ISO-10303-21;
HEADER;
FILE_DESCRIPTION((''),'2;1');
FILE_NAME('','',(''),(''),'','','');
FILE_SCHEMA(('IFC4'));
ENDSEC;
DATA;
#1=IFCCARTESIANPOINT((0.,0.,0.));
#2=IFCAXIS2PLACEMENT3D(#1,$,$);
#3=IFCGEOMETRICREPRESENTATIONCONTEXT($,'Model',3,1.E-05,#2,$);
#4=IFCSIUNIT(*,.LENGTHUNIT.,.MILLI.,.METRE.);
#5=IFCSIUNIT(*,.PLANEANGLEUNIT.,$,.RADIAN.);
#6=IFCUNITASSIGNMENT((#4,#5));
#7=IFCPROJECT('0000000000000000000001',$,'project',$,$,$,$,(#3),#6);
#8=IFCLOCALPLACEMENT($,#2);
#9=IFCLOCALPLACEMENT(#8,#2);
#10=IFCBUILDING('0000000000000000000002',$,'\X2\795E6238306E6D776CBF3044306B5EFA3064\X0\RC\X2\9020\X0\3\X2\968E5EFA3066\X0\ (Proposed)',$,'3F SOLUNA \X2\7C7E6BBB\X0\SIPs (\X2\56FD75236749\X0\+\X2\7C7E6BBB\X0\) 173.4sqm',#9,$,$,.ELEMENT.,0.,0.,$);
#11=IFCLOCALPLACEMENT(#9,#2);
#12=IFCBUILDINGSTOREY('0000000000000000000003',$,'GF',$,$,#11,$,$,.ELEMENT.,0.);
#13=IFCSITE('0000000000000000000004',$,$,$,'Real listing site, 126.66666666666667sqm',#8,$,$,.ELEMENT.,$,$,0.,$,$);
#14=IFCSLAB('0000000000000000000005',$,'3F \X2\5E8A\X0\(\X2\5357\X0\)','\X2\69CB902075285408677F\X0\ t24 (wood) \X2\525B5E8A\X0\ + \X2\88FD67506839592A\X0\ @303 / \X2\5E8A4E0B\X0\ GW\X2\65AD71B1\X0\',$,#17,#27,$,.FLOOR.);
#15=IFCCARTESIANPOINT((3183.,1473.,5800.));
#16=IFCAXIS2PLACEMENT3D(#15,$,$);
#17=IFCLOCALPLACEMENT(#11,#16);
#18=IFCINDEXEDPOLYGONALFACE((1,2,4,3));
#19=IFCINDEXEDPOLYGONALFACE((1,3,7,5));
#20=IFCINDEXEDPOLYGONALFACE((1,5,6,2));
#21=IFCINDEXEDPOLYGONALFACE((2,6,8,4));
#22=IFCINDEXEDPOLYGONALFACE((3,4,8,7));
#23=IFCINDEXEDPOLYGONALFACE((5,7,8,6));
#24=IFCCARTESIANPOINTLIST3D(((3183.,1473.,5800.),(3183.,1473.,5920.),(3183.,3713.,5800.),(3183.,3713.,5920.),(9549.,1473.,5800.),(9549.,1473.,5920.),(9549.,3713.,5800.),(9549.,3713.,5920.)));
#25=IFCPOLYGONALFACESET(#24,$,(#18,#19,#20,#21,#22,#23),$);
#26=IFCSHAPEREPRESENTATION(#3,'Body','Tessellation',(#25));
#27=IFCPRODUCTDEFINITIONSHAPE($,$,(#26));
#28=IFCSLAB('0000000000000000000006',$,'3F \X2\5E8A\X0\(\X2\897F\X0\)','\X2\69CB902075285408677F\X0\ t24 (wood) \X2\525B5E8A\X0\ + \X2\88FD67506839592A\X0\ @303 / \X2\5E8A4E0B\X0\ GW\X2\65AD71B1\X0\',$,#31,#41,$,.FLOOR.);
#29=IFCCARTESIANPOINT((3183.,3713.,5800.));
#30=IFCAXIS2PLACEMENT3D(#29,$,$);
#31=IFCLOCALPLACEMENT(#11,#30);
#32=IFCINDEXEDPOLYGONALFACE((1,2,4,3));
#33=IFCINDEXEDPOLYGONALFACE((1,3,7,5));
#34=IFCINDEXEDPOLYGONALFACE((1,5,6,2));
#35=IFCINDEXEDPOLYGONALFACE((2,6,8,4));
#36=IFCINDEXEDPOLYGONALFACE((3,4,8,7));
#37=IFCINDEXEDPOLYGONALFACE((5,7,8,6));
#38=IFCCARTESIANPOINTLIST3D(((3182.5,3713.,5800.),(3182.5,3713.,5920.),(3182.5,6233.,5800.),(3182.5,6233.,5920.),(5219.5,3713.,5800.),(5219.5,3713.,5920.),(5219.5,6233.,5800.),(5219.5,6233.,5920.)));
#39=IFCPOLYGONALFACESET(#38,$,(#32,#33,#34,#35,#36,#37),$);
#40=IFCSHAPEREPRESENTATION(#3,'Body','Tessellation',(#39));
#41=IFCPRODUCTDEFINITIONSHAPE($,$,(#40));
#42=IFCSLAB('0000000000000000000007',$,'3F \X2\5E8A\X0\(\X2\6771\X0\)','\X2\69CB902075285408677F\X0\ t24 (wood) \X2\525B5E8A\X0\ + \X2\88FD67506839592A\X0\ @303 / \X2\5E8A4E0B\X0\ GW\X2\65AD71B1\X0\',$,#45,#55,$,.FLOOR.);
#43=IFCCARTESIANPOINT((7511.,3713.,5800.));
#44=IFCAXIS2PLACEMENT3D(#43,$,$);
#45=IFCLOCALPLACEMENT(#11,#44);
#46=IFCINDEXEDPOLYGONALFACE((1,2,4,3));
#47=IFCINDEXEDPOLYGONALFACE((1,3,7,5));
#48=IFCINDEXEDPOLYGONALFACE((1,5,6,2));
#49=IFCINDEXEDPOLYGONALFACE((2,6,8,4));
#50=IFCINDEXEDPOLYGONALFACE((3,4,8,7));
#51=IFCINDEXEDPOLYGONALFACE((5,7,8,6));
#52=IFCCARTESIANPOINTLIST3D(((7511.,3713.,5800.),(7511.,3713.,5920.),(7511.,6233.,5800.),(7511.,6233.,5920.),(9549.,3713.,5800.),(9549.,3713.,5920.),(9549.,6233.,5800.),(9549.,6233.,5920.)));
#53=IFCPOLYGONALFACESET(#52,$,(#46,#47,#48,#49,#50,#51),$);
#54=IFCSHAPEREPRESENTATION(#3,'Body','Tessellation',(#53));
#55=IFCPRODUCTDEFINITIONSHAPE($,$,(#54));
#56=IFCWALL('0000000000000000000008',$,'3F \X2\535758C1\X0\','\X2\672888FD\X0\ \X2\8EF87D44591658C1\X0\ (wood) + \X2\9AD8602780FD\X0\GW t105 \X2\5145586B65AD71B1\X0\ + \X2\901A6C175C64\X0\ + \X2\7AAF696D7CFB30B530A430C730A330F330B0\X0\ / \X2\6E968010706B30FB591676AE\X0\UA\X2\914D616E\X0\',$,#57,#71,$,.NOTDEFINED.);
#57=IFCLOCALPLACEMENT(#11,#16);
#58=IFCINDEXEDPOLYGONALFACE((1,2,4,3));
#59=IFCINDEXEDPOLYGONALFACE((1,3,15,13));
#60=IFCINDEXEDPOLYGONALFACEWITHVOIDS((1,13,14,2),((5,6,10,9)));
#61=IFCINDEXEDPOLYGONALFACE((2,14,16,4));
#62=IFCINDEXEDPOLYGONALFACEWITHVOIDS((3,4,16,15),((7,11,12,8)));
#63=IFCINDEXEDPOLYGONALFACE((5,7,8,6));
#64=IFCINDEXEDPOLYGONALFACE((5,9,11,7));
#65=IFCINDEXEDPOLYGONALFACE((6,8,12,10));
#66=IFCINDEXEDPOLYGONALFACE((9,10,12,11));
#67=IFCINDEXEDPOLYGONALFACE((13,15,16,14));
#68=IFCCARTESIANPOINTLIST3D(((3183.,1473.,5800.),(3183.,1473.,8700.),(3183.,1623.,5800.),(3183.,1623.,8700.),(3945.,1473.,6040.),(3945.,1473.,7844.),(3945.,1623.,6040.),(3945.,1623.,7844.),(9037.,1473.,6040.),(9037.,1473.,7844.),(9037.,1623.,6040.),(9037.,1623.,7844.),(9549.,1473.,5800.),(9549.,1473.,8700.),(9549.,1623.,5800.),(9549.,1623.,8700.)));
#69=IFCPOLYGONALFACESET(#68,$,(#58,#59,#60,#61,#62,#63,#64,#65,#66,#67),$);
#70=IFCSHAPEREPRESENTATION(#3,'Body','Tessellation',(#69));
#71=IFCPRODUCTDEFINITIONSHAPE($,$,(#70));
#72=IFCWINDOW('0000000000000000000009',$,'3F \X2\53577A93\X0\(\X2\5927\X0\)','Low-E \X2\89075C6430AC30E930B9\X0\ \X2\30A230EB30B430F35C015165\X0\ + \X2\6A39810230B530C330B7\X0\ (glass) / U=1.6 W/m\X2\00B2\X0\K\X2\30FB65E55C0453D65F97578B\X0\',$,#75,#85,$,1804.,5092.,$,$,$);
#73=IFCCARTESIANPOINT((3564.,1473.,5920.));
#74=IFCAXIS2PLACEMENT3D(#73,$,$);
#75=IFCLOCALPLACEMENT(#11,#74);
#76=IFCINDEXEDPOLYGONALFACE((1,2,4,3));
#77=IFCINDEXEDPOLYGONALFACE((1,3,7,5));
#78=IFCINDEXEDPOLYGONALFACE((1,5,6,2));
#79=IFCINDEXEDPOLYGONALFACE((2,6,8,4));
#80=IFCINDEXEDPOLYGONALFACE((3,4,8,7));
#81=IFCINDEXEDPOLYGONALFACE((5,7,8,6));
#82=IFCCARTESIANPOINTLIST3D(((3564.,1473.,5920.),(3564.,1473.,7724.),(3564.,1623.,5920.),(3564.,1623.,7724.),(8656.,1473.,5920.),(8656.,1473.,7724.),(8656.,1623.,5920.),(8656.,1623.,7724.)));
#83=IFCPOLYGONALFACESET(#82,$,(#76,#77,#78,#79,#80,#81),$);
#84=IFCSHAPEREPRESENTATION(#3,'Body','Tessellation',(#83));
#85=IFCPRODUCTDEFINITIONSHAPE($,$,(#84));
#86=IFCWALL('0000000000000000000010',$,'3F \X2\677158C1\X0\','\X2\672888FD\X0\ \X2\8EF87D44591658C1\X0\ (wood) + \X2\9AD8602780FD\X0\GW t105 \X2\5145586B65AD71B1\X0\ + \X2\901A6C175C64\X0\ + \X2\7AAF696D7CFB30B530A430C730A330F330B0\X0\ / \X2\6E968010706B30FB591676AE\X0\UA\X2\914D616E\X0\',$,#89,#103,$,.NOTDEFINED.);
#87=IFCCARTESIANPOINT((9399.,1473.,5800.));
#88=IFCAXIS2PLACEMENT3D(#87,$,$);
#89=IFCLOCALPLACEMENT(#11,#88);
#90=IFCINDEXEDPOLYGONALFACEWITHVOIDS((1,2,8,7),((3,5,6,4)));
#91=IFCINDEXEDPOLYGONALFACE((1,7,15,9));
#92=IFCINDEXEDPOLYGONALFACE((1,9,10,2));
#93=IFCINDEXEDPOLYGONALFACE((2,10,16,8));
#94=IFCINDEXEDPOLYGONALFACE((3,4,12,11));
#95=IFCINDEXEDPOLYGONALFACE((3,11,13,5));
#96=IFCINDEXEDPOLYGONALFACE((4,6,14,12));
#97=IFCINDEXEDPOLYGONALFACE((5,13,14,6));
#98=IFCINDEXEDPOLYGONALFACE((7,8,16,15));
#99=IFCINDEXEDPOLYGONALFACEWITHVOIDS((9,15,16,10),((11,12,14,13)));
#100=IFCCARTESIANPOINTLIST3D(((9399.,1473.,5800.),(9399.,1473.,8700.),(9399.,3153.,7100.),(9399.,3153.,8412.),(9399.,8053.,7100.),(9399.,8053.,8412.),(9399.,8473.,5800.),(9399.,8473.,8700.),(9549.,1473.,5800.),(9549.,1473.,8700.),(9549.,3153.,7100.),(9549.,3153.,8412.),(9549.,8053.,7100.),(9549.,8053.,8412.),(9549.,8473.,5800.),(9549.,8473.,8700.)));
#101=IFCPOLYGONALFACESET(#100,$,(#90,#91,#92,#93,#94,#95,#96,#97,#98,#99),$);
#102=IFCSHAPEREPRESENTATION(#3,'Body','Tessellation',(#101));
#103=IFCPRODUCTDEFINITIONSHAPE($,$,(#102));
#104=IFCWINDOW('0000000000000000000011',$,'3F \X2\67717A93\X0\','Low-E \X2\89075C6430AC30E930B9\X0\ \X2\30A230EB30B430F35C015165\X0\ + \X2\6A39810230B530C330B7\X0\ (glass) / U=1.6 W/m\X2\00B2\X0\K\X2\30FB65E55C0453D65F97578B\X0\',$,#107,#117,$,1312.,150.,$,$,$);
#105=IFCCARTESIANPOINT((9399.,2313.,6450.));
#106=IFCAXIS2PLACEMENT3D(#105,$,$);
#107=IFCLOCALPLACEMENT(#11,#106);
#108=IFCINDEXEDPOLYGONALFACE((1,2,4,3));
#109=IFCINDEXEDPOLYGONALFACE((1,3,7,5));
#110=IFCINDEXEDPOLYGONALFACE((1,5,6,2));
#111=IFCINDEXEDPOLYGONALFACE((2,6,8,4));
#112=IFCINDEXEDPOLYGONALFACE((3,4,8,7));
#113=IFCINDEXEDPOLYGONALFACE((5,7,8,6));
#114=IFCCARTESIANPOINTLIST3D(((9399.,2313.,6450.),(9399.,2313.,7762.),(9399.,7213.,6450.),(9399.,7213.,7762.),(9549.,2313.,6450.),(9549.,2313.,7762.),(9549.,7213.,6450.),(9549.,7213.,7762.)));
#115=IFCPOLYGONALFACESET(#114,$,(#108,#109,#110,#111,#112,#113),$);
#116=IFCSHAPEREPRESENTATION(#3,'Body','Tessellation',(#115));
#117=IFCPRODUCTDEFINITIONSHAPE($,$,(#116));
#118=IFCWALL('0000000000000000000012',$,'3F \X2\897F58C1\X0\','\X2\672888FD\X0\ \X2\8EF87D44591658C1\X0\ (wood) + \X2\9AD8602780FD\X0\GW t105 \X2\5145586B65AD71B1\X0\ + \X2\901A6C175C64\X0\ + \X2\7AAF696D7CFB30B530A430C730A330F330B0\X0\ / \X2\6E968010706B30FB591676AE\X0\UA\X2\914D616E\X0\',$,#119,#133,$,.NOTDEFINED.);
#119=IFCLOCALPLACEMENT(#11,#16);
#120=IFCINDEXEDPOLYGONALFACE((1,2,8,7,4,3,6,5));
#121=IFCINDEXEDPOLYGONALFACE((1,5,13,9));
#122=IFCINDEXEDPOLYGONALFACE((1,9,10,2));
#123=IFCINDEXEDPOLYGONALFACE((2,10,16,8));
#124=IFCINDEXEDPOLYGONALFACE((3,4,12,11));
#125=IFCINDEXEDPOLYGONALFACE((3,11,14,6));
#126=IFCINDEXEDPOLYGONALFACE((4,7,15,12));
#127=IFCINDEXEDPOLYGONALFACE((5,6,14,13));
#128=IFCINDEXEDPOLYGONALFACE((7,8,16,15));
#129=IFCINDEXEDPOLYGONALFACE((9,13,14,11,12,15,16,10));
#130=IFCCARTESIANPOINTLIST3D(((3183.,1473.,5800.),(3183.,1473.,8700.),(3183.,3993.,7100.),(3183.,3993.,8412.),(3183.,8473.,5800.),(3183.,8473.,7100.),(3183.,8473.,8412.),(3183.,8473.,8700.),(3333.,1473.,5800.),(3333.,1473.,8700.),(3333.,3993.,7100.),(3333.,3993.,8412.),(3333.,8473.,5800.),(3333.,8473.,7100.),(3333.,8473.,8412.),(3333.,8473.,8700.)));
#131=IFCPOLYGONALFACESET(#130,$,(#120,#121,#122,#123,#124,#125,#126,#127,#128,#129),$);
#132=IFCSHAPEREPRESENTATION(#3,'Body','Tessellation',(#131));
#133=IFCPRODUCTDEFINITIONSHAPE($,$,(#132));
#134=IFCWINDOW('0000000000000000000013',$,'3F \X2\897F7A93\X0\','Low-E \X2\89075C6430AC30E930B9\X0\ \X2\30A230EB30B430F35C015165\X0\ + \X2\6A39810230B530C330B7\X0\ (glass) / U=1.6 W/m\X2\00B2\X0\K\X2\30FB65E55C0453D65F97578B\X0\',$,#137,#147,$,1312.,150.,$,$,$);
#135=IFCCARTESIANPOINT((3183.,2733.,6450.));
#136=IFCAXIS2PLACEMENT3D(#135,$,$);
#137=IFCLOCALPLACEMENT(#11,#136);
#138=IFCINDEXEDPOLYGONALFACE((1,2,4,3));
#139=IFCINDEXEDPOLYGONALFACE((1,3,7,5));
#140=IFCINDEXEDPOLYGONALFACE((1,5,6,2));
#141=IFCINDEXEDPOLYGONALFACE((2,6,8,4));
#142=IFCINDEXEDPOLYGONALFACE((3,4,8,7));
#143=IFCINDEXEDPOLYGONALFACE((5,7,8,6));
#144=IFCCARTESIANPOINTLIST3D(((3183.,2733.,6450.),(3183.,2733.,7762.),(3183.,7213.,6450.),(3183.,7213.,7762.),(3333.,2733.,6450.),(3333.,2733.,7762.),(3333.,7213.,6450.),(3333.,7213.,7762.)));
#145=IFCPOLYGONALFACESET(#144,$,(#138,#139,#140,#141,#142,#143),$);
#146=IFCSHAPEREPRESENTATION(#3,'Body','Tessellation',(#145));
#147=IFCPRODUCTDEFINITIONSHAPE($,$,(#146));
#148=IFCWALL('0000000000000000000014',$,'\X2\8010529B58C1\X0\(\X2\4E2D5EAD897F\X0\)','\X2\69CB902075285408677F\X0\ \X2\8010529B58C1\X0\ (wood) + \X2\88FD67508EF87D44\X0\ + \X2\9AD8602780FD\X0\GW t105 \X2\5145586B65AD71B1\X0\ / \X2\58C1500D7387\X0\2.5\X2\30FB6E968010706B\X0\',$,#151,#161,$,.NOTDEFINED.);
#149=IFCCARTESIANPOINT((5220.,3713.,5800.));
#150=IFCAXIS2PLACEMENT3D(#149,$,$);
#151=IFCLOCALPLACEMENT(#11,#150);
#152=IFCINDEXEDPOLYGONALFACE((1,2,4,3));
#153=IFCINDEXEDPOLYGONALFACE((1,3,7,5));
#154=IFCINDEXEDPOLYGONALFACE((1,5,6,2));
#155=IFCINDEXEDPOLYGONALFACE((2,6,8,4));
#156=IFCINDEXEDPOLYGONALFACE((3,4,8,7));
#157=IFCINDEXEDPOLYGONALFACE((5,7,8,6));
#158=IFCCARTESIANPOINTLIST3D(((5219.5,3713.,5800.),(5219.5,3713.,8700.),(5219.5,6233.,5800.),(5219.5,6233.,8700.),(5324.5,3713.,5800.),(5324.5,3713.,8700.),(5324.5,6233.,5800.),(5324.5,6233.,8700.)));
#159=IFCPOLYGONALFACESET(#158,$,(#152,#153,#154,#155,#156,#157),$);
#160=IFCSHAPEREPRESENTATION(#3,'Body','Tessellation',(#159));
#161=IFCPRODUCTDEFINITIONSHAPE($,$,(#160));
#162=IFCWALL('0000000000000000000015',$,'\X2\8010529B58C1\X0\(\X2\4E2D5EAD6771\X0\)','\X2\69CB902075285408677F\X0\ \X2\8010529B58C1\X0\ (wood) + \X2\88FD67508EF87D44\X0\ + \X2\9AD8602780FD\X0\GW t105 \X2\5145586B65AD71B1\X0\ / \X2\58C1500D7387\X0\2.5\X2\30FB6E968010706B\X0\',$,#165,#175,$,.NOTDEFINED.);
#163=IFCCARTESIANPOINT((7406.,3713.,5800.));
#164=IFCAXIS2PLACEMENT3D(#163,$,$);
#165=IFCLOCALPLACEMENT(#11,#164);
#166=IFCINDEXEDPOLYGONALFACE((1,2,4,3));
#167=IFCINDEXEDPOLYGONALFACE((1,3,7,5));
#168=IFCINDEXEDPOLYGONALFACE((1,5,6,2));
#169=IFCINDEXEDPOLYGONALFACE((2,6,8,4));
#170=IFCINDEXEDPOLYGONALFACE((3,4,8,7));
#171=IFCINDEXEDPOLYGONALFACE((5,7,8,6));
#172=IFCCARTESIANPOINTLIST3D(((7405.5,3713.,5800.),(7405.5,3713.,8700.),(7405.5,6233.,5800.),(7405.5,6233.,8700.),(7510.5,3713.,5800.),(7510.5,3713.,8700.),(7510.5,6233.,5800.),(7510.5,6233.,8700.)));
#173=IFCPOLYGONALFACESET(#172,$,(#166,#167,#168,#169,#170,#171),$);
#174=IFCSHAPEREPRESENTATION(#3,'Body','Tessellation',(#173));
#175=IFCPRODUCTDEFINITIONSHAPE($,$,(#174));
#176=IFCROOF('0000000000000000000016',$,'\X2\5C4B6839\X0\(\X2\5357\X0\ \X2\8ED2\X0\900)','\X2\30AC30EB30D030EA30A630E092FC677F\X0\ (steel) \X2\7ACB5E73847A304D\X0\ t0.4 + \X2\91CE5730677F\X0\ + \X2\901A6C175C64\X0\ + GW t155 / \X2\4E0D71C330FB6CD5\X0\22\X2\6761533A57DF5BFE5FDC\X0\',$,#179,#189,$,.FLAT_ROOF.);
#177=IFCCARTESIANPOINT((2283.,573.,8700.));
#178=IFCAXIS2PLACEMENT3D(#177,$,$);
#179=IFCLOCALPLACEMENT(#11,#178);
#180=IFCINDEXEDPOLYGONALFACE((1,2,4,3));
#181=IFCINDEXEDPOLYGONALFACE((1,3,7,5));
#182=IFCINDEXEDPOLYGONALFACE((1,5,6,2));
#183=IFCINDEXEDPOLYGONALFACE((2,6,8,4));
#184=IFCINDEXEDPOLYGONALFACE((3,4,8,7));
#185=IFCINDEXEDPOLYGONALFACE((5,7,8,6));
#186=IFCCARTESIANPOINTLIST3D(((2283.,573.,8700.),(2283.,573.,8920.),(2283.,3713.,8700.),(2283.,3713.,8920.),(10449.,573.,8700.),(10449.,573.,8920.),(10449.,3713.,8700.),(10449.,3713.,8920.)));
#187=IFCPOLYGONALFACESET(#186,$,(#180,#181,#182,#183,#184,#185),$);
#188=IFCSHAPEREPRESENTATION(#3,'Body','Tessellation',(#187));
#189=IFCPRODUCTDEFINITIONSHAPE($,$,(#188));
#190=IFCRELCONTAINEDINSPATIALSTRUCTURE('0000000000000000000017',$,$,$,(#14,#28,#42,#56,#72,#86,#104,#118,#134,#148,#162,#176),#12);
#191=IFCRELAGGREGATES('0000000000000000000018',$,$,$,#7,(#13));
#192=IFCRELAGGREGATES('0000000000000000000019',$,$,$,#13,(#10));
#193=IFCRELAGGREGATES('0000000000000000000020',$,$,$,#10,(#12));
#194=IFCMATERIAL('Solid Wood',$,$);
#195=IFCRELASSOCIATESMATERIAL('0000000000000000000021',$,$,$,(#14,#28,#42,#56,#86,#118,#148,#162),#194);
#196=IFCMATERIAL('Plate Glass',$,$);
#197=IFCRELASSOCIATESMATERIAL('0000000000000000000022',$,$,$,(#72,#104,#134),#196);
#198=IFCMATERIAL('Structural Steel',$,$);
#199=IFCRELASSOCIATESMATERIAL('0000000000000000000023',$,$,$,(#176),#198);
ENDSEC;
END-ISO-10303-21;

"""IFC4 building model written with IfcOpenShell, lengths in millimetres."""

from ifc_helpers import new_model, si_unit, frame, frame_2d, origin, place, context, project, spatial, rectangle, extrude, material, element, fill, save


model = new_model("IFC4")

# Units and contexts
model_context = context("Model", 3, precision=1e-05, world=origin())
ifc_project = project(units=[si_unit("LENGTHUNIT", "METRE", prefix="MILLI"), si_unit("PLANEANGLEUNIT", "RADIAN")], contexts=[model_context])

# Site, building, storey
site_placement = place(None, origin())
site = spatial("IfcSite", under=ifc_project, at=site_placement, ObjectType="Real listing site, 126.66666666666667sqm", CompositionType="ELEMENT", RefElevation=0.0)
building_placement = place(site_placement, origin())
building = spatial("IfcBuilding", under=site, at=building_placement, Name="神戸の海沿いに建つRC造3階建て (Proposed)", ObjectType="3F SOLUNA 籾殻SIPs (国産杉+籾殻) 173.4sqm", CompositionType="ELEMENT", ElevationOfRefHeight=0.0, ElevationOfTerrain=0.0)
storey_placement = place(building_placement, origin())
storey = spatial("IfcBuildingStorey", under=building, at=storey_placement, Name="GF", CompositionType="ELEMENT", Elevation=0.0)

# Slabs
ifc_material_1 = material(Name="Solid Wood")
slab_1_placement = place(storey_placement, frame((3183.0, 1473.0, 5800.0)))
element("IfcSlab", 1, at=slab_1_placement, inside=storey, material=ifc_material_1, Name="3F 床(南)", Description="構造用合板 t24 (wood) 剛床 + 製材根太 @303 / 床下 GW断熱", PredefinedType="FLOOR", context=model_context, shape_type="SweptSolid", body=[
    extrude(rectangle(XDim=6366.0, YDim=2240.0, at=frame_2d((3183.0, 1120.0))), frame((3183.0, 1473.0, 5800.0)), (0.0, 0.0, 1.0), 120.0),
])
slab_2_placement = place(storey_placement, frame((3183.0, 3713.0, 5800.0)))
element("IfcSlab", 2, at=slab_2_placement, inside=storey, material=ifc_material_1, Name="3F 床(西)", Description="構造用合板 t24 (wood) 剛床 + 製材根太 @303 / 床下 GW断熱", PredefinedType="FLOOR", context=model_context, shape_type="SweptSolid", body=[
    extrude(rectangle(XDim=2037.0, YDim=2520.0, at=frame_2d((1018.0, 1260.0))), frame((3183.0, 3713.0, 5800.0)), (0.0, 0.0, 1.0), 120.0),
])
slab_3_placement = place(storey_placement, frame((7511.0, 3713.0, 5800.0)))
element("IfcSlab", 3, at=slab_3_placement, inside=storey, material=ifc_material_1, Name="3F 床(東)", Description="構造用合板 t24 (wood) 剛床 + 製材根太 @303 / 床下 GW断熱", PredefinedType="FLOOR", context=model_context, shape_type="SweptSolid", body=[
    extrude(rectangle(XDim=2038.0, YDim=2520.0, at=frame_2d((1019.0, 1260.0))), frame((7511.0, 3713.0, 5800.0)), (0.0, 0.0, 1.0), 120.0),
])

# Walls, openings, windows
wall_1_placement = place(storey_placement, frame((3183.0, 1473.0, 5800.0)))
wall_1 = element("IfcWall", 4, at=wall_1_placement, inside=storey, material=ifc_material_1, Name="3F 南壁", Description="木製 軸組外壁 (wood) + 高性能GW t105 充填断熱 + 通気層 + 窯業系サイディング / 準耐火・外皮UA配慮", PredefinedType="NOTDEFINED", context=model_context, shape_type="SweptSolid", body=[
    extrude(rectangle(XDim=6366.0, YDim=150.0, at=frame_2d((3183.0, 75.0))), frame((3183.0, 1473.0, 5800.0)), (0.0, 0.0, 1.0), 2900.0),
])
opening_1_placement = place(storey_placement, frame((3564.0, 1473.0, 5920.0)))
opening_1 = element("IfcOpeningElement", 5, at=opening_1_placement, cuts=wall_1, PredefinedType="NOTDEFINED", context=model_context, shape_type="SweptSolid", body=[
    extrude(rectangle(XDim=5092.0, YDim=150.0, at=frame_2d((2546.0, 75.0))), frame((3564.0, 1473.0, 5920.0)), (0.0, 0.0, 1.0), 1804.0),
])
ifc_material_2 = material(Name="Plate Glass")
window_1_placement = place(storey_placement, frame((3564.0, 1473.0, 5920.0)))
window_1 = element("IfcWindow", 6, at=window_1_placement, inside=storey, material=ifc_material_2, Name="3F 南窓(大)", Description="Low-E 複層ガラス アルゴン封入 + 樹脂サッシ (glass) / U=1.6 W/m²K・日射取得型", OverallHeight=1804.0, OverallWidth=5092.0, context=model_context, shape_type="SweptSolid", body=[
    extrude(rectangle(XDim=5092.0, YDim=150.0, at=frame_2d((2546.0, 75.0))), frame((3564.0, 1473.0, 5920.0)), (0.0, 0.0, 1.0), 1804.0),
])
fill(opening_1, window_1)
wall_2_placement = place(storey_placement, frame((9399.0, 1473.0, 5800.0)))
wall_2 = element("IfcWall", 7, at=wall_2_placement, inside=storey, material=ifc_material_1, Name="3F 東壁", Description="木製 軸組外壁 (wood) + 高性能GW t105 充填断熱 + 通気層 + 窯業系サイディング / 準耐火・外皮UA配慮", PredefinedType="NOTDEFINED", context=model_context, shape_type="SweptSolid", body=[
    extrude(rectangle(XDim=150.0, YDim=7000.0, at=frame_2d((75.0, 3500.0))), frame((9399.0, 1473.0, 5800.0)), (0.0, 0.0, 1.0), 2900.0),
])
opening_2_placement = place(storey_placement, frame((9399.0, 2313.0, 6450.0)))
opening_2 = element("IfcOpeningElement", 8, at=opening_2_placement, cuts=wall_2, PredefinedType="NOTDEFINED", context=model_context, shape_type="SweptSolid", body=[
    extrude(rectangle(XDim=150.0, YDim=4900.0, at=frame_2d((75.0, 2450.0))), frame((9399.0, 2313.0, 6450.0)), (0.0, 0.0, 1.0), 1312.0),
])
window_2_placement = place(storey_placement, frame((9399.0, 2313.0, 6450.0)))
window_2 = element("IfcWindow", 9, at=window_2_placement, inside=storey, material=ifc_material_2, Name="3F 東窓", Description="Low-E 複層ガラス アルゴン封入 + 樹脂サッシ (glass) / U=1.6 W/m²K・日射取得型", OverallHeight=1312.0, OverallWidth=150.0, context=model_context, shape_type="SweptSolid", body=[
    extrude(rectangle(XDim=150.0, YDim=4900.0, at=frame_2d((75.0, 2450.0))), frame((9399.0, 2313.0, 6450.0)), (0.0, 0.0, 1.0), 1312.0),
])
fill(opening_2, window_2)
wall_3_placement = place(storey_placement, frame((3183.0, 1473.0, 5800.0)))
wall_3 = element("IfcWall", 10, at=wall_3_placement, inside=storey, material=ifc_material_1, Name="3F 西壁", Description="木製 軸組外壁 (wood) + 高性能GW t105 充填断熱 + 通気層 + 窯業系サイディング / 準耐火・外皮UA配慮", PredefinedType="NOTDEFINED", context=model_context, shape_type="SweptSolid", body=[
    extrude(rectangle(XDim=150.0, YDim=7000.0, at=frame_2d((75.0, 3500.0))), frame((3183.0, 1473.0, 5800.0)), (0.0, 0.0, 1.0), 2900.0),
])
opening_3_placement = place(storey_placement, frame((3183.0, 2733.0, 6450.0)))
opening_3 = element("IfcOpeningElement", 11, at=opening_3_placement, cuts=wall_3, PredefinedType="NOTDEFINED", context=model_context, shape_type="SweptSolid", body=[
    extrude(rectangle(XDim=150.0, YDim=4480.0, at=frame_2d((75.0, 2240.0))), frame((3183.0, 2733.0, 6450.0)), (0.0, 0.0, 1.0), 1312.0),
])
window_3_placement = place(storey_placement, frame((3183.0, 2733.0, 6450.0)))
window_3 = element("IfcWindow", 12, at=window_3_placement, inside=storey, material=ifc_material_2, Name="3F 西窓", Description="Low-E 複層ガラス アルゴン封入 + 樹脂サッシ (glass) / U=1.6 W/m²K・日射取得型", OverallHeight=1312.0, OverallWidth=150.0, context=model_context, shape_type="SweptSolid", body=[
    extrude(rectangle(XDim=150.0, YDim=4480.0, at=frame_2d((75.0, 2240.0))), frame((3183.0, 2733.0, 6450.0)), (0.0, 0.0, 1.0), 1312.0),
])
fill(opening_3, window_3)

# Walls
wall_4_placement = place(storey_placement, frame((5220.0, 3713.0, 5800.0)))
element("IfcWall", 13, at=wall_4_placement, inside=storey, material=ifc_material_1, Name="耐力壁(中庭西)", Description="構造用合板 耐力壁 (wood) + 製材軸組 + 高性能GW t105 充填断熱 / 壁倍率2.5・準耐火", PredefinedType="NOTDEFINED", context=model_context, shape_type="SweptSolid", body=[
    extrude(rectangle(XDim=105.0, YDim=2520.0, at=frame_2d((52.0, 1260.0))), frame((5220.0, 3713.0, 5800.0)), (0.0, 0.0, 1.0), 2900.0),
])
wall_5_placement = place(storey_placement, frame((7406.0, 3713.0, 5800.0)))
element("IfcWall", 14, at=wall_5_placement, inside=storey, material=ifc_material_1, Name="耐力壁(中庭東)", Description="構造用合板 耐力壁 (wood) + 製材軸組 + 高性能GW t105 充填断熱 / 壁倍率2.5・準耐火", PredefinedType="NOTDEFINED", context=model_context, shape_type="SweptSolid", body=[
    extrude(rectangle(XDim=105.0, YDim=2520.0, at=frame_2d((52.0, 1260.0))), frame((7406.0, 3713.0, 5800.0)), (0.0, 0.0, 1.0), 2900.0),
])

# Roof
ifc_material_3 = material(Name="Structural Steel")
roof_1_placement = place(storey_placement, frame((2283.0, 573.0, 8700.0)))
element("IfcRoof", 15, at=roof_1_placement, inside=storey, material=ifc_material_3, Name="屋根(南 軒900)", Description="ガルバリウム鋼板 (steel) 立平葺き t0.4 + 野地板 + 通気層 + GW t155 / 不燃・法22条区域対応", PredefinedType="FLAT_ROOF", context=model_context, shape_type="SweptSolid", body=[
    extrude(rectangle(XDim=8166.0, YDim=3140.0, at=frame_2d((4083.0, 1570.0))), frame((2283.0, 573.0, 8700.0)), (0.0, 0.0, 1.0), 220.0),
])

save(model, "model.ifc")
